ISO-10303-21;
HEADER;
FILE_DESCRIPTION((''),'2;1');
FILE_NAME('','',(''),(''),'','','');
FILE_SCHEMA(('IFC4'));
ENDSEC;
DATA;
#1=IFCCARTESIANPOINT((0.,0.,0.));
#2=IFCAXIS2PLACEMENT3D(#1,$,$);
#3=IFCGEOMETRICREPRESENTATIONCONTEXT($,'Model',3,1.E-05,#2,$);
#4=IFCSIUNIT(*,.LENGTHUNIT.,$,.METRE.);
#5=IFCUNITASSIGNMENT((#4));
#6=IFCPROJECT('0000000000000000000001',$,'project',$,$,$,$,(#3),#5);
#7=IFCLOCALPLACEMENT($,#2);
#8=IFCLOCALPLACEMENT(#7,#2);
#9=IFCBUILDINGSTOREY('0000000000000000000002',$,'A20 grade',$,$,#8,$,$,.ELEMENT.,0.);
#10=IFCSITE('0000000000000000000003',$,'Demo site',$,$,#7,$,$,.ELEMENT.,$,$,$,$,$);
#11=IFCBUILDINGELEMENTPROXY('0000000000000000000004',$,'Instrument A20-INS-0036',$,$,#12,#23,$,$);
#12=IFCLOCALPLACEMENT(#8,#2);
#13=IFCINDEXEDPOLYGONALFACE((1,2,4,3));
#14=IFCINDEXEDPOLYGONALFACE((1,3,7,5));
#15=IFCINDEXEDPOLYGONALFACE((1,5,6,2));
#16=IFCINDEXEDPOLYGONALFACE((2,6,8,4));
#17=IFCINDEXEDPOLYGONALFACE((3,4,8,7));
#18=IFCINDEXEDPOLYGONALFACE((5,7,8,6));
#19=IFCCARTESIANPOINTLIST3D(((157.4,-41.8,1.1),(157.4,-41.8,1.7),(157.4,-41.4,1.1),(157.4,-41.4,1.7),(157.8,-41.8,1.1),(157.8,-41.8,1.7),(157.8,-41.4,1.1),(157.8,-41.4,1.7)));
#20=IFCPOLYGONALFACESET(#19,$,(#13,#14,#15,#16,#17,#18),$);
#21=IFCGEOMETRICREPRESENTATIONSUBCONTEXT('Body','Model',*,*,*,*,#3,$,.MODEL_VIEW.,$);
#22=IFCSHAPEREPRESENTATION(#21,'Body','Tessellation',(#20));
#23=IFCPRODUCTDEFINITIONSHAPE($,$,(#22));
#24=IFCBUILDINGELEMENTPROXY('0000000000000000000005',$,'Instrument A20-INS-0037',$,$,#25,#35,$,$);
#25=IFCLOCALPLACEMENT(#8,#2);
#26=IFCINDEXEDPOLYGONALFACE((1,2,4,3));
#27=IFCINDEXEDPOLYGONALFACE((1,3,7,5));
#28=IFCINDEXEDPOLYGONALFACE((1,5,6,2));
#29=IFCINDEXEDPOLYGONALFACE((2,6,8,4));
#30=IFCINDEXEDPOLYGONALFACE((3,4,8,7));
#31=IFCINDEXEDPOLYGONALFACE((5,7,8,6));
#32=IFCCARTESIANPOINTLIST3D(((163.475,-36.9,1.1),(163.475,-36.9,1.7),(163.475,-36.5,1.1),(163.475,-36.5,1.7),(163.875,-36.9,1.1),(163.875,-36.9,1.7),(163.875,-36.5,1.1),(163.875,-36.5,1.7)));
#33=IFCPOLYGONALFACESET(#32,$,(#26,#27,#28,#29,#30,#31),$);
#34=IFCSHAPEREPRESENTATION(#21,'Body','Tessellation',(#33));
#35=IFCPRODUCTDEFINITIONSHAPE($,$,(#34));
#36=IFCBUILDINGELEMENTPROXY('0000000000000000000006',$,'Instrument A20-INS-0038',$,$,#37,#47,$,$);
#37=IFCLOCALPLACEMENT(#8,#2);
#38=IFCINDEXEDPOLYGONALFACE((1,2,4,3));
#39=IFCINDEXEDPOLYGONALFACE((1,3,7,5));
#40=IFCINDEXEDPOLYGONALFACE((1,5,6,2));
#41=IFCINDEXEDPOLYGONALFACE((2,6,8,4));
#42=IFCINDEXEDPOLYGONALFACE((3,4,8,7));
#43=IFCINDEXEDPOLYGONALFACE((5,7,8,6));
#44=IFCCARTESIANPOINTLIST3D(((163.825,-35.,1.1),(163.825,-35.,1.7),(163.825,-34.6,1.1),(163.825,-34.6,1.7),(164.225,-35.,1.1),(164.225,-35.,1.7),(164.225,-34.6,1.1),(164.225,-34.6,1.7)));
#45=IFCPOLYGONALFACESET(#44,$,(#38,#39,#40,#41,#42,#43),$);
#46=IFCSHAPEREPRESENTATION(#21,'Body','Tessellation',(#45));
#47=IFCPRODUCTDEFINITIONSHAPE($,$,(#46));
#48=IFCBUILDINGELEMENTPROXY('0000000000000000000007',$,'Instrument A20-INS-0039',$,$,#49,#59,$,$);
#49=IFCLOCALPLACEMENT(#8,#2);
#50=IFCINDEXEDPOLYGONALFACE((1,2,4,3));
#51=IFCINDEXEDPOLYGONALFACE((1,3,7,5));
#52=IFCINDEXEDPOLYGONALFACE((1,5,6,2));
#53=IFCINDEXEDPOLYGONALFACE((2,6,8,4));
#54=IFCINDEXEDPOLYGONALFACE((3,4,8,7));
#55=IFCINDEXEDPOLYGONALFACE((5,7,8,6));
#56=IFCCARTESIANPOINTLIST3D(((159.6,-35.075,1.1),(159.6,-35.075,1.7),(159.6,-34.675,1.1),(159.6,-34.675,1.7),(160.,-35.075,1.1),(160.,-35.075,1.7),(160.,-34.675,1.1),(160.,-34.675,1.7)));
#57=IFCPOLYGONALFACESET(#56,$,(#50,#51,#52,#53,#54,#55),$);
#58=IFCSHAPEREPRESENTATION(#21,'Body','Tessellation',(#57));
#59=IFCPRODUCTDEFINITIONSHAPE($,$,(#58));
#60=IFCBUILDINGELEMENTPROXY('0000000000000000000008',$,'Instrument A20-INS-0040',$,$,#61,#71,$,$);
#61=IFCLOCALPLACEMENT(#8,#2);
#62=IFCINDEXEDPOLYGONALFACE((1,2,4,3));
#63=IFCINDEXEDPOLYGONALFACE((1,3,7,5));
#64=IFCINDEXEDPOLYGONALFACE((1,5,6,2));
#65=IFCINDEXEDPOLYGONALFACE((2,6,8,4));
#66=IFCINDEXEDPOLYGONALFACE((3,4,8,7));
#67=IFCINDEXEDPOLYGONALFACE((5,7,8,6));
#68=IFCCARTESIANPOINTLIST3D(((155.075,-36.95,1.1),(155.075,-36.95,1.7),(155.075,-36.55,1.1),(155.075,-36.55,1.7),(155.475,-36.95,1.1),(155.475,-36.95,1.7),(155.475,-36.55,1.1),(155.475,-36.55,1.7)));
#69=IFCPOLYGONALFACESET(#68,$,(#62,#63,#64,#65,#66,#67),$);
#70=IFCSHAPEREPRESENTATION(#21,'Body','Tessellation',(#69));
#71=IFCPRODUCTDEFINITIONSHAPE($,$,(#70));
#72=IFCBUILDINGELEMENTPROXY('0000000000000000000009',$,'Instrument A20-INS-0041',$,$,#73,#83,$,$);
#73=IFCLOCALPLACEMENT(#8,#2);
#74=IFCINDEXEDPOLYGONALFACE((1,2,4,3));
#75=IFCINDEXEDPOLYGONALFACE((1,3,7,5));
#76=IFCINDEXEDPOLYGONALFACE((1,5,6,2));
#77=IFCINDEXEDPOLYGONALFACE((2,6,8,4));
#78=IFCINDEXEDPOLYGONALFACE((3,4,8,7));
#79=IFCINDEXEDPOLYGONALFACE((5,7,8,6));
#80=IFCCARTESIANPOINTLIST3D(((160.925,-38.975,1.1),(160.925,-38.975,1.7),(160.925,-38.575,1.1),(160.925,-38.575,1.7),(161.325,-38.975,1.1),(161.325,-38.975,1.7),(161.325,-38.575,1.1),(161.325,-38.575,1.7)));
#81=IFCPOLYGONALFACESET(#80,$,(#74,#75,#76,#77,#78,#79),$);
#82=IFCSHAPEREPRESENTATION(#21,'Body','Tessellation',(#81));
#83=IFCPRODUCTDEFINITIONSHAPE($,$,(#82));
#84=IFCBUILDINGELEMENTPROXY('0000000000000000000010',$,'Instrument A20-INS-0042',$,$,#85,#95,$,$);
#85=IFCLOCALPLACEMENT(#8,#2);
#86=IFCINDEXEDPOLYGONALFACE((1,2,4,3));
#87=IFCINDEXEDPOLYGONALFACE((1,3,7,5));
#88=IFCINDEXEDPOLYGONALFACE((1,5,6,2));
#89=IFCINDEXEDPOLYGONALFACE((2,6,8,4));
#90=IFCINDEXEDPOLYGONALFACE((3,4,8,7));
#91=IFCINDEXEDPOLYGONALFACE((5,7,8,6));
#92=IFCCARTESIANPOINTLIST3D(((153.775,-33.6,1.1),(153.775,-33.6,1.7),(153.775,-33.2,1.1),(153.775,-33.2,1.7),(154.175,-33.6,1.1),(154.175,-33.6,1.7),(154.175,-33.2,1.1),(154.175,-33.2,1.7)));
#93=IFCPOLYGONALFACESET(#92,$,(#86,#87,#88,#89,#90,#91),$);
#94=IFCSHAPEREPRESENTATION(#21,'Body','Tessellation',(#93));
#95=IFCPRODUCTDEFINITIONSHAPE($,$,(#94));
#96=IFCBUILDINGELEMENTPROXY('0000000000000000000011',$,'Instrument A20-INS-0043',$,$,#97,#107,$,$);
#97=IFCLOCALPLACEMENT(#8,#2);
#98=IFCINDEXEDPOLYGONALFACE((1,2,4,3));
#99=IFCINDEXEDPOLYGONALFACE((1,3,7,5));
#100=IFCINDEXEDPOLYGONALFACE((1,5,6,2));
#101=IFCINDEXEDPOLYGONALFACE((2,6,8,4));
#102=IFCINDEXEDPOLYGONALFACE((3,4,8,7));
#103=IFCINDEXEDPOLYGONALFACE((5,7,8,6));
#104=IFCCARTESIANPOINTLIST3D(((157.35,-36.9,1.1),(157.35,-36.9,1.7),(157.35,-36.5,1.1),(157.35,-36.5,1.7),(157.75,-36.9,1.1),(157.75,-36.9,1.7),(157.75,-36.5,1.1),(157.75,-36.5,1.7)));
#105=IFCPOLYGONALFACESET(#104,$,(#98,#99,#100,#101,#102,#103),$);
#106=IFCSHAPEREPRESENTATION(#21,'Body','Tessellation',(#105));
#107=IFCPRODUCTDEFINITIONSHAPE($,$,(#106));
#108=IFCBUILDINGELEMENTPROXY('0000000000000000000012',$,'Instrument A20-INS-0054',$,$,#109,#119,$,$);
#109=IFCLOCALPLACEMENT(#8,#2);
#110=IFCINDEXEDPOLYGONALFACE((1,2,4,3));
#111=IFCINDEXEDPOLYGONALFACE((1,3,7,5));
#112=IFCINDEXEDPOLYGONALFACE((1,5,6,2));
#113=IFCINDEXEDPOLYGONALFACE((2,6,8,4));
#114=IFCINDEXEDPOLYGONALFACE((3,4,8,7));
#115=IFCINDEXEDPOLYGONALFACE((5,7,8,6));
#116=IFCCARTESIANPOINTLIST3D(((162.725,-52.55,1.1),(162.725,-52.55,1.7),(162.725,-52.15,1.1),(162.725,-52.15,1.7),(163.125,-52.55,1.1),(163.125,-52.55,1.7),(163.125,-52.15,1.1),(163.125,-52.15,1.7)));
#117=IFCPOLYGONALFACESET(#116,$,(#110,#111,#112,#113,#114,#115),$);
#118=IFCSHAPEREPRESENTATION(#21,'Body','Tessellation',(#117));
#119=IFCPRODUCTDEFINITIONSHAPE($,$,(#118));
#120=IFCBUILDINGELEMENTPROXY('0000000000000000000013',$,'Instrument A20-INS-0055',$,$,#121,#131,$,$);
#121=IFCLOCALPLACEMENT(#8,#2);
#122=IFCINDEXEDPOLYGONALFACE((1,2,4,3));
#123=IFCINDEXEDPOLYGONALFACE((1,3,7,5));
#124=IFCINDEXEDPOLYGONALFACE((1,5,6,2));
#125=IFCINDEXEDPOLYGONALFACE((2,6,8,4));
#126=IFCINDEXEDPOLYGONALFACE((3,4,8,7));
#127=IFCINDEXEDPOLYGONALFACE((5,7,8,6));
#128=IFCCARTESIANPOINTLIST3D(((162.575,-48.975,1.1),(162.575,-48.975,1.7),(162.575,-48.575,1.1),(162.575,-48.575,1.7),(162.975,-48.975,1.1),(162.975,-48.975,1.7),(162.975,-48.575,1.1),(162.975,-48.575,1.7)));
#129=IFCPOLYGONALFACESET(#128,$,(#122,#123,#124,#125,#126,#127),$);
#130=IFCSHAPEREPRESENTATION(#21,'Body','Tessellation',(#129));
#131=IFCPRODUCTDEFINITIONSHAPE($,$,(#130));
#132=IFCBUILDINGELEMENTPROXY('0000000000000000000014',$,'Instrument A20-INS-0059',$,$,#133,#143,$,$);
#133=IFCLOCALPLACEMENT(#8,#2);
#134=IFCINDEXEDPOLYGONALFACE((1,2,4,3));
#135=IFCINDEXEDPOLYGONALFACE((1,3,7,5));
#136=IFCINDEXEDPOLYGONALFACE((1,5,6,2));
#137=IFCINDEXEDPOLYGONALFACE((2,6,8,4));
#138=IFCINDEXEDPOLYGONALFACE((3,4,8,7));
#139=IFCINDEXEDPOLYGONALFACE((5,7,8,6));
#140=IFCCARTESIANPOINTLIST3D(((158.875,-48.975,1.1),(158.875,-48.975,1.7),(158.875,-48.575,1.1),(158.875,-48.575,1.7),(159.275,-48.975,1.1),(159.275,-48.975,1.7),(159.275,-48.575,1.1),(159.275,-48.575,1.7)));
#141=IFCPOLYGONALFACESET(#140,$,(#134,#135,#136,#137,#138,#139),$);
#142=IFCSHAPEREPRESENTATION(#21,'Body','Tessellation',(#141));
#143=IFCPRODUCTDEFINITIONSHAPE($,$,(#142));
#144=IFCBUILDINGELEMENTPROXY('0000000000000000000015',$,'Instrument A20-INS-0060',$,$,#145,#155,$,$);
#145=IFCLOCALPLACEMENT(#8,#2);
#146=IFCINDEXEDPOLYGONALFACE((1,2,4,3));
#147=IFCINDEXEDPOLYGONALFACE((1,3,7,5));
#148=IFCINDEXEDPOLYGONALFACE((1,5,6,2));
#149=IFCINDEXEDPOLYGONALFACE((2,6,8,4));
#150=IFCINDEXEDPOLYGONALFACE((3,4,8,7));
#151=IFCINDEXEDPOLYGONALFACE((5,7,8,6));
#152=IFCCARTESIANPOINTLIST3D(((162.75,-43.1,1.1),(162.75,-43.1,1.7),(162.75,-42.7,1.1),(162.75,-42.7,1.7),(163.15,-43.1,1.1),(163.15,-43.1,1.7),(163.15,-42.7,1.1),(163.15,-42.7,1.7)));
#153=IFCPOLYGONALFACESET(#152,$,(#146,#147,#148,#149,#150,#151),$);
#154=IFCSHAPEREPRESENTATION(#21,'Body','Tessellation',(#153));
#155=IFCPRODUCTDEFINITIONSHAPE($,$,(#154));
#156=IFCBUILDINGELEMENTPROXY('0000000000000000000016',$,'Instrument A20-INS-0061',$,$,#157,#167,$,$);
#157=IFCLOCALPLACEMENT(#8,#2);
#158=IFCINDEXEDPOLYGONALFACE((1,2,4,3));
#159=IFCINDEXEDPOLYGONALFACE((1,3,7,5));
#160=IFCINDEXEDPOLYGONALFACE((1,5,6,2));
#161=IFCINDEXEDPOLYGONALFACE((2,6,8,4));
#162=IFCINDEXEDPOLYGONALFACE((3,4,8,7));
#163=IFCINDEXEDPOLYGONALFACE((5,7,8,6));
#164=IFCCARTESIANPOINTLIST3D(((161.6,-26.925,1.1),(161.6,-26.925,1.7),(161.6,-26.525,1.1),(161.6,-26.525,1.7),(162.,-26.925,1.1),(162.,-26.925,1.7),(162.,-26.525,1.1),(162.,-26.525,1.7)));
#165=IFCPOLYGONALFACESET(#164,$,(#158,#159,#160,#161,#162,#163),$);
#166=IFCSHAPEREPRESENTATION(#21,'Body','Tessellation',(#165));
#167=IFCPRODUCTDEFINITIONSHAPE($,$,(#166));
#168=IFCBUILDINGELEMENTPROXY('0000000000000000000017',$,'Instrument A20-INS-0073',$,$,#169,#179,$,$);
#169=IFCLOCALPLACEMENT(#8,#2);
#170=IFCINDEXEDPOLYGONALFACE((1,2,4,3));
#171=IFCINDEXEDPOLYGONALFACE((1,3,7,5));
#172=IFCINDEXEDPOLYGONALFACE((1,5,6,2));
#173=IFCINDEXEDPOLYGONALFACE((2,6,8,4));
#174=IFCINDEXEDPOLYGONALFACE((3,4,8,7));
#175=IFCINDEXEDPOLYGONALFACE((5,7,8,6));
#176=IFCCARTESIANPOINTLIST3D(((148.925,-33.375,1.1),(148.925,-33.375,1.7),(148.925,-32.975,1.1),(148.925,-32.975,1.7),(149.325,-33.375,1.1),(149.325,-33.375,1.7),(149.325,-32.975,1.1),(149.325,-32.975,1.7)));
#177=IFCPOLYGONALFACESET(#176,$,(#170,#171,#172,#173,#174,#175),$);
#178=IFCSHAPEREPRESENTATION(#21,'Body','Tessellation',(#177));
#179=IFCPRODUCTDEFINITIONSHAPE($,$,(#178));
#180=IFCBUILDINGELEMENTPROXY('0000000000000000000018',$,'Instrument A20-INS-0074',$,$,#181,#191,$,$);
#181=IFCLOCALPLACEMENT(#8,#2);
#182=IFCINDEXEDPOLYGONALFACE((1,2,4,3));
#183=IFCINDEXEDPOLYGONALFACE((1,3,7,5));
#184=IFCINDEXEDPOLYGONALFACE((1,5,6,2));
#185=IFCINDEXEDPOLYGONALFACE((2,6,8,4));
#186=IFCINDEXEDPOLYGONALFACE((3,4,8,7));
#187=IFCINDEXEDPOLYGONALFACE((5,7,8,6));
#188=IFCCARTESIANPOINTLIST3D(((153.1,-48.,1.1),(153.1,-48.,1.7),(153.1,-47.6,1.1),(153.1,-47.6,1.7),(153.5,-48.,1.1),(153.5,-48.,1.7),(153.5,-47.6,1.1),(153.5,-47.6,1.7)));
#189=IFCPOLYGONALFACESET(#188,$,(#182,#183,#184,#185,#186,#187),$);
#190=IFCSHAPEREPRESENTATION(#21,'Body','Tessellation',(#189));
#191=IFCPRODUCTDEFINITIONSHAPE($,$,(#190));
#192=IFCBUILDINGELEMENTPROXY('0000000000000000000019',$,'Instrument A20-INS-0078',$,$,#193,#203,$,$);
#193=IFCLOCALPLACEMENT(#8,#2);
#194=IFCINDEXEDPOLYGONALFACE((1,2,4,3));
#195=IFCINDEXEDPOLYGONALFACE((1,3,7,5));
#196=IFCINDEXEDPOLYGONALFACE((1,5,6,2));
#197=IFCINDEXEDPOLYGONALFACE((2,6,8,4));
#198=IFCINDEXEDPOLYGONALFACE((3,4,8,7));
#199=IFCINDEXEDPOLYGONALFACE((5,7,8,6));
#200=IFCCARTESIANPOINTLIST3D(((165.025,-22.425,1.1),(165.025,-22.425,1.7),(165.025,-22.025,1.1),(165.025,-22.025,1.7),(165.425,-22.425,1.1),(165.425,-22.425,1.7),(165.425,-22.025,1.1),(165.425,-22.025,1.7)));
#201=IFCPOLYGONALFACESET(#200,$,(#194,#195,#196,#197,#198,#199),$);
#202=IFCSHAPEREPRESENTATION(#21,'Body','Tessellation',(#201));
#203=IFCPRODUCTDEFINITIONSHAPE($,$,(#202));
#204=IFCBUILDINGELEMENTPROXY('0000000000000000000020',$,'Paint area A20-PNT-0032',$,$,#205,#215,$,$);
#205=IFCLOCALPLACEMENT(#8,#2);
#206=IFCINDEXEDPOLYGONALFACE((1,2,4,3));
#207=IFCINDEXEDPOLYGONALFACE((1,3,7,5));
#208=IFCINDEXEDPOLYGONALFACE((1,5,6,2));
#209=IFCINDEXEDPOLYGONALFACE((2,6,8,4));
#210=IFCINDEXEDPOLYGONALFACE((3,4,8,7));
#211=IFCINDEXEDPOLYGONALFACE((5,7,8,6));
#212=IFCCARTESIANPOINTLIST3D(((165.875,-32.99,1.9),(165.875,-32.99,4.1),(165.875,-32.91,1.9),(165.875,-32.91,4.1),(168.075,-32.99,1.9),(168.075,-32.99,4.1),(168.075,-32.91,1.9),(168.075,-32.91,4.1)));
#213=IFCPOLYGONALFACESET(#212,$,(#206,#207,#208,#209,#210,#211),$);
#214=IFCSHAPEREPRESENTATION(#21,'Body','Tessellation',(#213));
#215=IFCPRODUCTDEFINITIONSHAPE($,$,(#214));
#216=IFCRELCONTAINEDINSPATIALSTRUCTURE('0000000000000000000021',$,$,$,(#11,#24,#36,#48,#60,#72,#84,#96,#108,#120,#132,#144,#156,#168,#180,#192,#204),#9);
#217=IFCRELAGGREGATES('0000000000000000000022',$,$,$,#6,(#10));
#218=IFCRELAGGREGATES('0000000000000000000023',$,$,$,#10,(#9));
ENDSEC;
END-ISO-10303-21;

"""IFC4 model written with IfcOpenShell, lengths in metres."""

from ifc_helpers import new_model, si_unit, frame, origin, place, context, subcontext, project, spatial, rectangle, extrude, element, save


model = new_model("IFC4")

# Units and contexts
model_context = context("Model", 3, precision=1e-05, world=origin())
body_context = subcontext(model_context, "Body", "Model", "MODEL_VIEW")
ifc_project = project(units=[si_unit("LENGTHUNIT", "METRE")], contexts=[model_context])

# Site, storey
site_placement = place(None, origin())
site = spatial("IfcSite", under=ifc_project, at=site_placement, Name="Demo site", CompositionType="ELEMENT")
storey_placement = place(site_placement, origin())
storey = spatial("IfcBuildingStorey", under=site, at=storey_placement, Name="A20 grade", CompositionType="ELEMENT", Elevation=0.0)

# Building element proxies
for number, where, name in (
    (1, (157.6, -41.6, 1.1), "Instrument A20-INS-0036"),
    (2, (163.675, -36.7, 1.1), "Instrument A20-INS-0037"),
    (3, (164.025, -34.8, 1.1), "Instrument A20-INS-0038"),
    (4, (159.8, -34.875, 1.1), "Instrument A20-INS-0039"),
    (5, (155.275, -36.75, 1.1), "Instrument A20-INS-0040"),
    (6, (161.125, -38.775, 1.1), "Instrument A20-INS-0041"),
    (7, (153.975, -33.4, 1.1), "Instrument A20-INS-0042"),
    (8, (157.55, -36.7, 1.1), "Instrument A20-INS-0043"),
    (9, (162.925, -52.35, 1.1), "Instrument A20-INS-0054"),
    (10, (162.775, -48.775, 1.1), "Instrument A20-INS-0055"),
    (11, (159.075, -48.775, 1.1), "Instrument A20-INS-0059"),
    (12, (162.95, -42.9, 1.1), "Instrument A20-INS-0060"),
    (13, (161.8, -26.725, 1.1), "Instrument A20-INS-0061"),
    (14, (149.125, -33.175, 1.1), "Instrument A20-INS-0073"),
    (15, (153.3, -47.8, 1.1), "Instrument A20-INS-0074"),
    (16, (165.225, -22.225, 1.1), "Instrument A20-INS-0078"),
):
    element("IfcBuildingElementProxy", number, at=place(storey_placement, frame(where)), inside=storey, Name=name, context=body_context, shape_type="SweptSolid", body=[
        extrude(rectangle(XDim=0.4, YDim=0.4), origin(), (0.0, 0.0, 1.0), 0.6),
    ])
proxy_placement = place(storey_placement, frame((166.975, -32.95, 1.9)))
element("IfcBuildingElementProxy", 17, at=proxy_placement, inside=storey, Name="Paint area A20-PNT-0032", context=body_context, shape_type="SweptSolid", body=[
    extrude(rectangle(XDim=2.2, YDim=0.08), origin(), (0.0, 0.0, 1.0), 2.2),
])

save(model, "model.ifc")
